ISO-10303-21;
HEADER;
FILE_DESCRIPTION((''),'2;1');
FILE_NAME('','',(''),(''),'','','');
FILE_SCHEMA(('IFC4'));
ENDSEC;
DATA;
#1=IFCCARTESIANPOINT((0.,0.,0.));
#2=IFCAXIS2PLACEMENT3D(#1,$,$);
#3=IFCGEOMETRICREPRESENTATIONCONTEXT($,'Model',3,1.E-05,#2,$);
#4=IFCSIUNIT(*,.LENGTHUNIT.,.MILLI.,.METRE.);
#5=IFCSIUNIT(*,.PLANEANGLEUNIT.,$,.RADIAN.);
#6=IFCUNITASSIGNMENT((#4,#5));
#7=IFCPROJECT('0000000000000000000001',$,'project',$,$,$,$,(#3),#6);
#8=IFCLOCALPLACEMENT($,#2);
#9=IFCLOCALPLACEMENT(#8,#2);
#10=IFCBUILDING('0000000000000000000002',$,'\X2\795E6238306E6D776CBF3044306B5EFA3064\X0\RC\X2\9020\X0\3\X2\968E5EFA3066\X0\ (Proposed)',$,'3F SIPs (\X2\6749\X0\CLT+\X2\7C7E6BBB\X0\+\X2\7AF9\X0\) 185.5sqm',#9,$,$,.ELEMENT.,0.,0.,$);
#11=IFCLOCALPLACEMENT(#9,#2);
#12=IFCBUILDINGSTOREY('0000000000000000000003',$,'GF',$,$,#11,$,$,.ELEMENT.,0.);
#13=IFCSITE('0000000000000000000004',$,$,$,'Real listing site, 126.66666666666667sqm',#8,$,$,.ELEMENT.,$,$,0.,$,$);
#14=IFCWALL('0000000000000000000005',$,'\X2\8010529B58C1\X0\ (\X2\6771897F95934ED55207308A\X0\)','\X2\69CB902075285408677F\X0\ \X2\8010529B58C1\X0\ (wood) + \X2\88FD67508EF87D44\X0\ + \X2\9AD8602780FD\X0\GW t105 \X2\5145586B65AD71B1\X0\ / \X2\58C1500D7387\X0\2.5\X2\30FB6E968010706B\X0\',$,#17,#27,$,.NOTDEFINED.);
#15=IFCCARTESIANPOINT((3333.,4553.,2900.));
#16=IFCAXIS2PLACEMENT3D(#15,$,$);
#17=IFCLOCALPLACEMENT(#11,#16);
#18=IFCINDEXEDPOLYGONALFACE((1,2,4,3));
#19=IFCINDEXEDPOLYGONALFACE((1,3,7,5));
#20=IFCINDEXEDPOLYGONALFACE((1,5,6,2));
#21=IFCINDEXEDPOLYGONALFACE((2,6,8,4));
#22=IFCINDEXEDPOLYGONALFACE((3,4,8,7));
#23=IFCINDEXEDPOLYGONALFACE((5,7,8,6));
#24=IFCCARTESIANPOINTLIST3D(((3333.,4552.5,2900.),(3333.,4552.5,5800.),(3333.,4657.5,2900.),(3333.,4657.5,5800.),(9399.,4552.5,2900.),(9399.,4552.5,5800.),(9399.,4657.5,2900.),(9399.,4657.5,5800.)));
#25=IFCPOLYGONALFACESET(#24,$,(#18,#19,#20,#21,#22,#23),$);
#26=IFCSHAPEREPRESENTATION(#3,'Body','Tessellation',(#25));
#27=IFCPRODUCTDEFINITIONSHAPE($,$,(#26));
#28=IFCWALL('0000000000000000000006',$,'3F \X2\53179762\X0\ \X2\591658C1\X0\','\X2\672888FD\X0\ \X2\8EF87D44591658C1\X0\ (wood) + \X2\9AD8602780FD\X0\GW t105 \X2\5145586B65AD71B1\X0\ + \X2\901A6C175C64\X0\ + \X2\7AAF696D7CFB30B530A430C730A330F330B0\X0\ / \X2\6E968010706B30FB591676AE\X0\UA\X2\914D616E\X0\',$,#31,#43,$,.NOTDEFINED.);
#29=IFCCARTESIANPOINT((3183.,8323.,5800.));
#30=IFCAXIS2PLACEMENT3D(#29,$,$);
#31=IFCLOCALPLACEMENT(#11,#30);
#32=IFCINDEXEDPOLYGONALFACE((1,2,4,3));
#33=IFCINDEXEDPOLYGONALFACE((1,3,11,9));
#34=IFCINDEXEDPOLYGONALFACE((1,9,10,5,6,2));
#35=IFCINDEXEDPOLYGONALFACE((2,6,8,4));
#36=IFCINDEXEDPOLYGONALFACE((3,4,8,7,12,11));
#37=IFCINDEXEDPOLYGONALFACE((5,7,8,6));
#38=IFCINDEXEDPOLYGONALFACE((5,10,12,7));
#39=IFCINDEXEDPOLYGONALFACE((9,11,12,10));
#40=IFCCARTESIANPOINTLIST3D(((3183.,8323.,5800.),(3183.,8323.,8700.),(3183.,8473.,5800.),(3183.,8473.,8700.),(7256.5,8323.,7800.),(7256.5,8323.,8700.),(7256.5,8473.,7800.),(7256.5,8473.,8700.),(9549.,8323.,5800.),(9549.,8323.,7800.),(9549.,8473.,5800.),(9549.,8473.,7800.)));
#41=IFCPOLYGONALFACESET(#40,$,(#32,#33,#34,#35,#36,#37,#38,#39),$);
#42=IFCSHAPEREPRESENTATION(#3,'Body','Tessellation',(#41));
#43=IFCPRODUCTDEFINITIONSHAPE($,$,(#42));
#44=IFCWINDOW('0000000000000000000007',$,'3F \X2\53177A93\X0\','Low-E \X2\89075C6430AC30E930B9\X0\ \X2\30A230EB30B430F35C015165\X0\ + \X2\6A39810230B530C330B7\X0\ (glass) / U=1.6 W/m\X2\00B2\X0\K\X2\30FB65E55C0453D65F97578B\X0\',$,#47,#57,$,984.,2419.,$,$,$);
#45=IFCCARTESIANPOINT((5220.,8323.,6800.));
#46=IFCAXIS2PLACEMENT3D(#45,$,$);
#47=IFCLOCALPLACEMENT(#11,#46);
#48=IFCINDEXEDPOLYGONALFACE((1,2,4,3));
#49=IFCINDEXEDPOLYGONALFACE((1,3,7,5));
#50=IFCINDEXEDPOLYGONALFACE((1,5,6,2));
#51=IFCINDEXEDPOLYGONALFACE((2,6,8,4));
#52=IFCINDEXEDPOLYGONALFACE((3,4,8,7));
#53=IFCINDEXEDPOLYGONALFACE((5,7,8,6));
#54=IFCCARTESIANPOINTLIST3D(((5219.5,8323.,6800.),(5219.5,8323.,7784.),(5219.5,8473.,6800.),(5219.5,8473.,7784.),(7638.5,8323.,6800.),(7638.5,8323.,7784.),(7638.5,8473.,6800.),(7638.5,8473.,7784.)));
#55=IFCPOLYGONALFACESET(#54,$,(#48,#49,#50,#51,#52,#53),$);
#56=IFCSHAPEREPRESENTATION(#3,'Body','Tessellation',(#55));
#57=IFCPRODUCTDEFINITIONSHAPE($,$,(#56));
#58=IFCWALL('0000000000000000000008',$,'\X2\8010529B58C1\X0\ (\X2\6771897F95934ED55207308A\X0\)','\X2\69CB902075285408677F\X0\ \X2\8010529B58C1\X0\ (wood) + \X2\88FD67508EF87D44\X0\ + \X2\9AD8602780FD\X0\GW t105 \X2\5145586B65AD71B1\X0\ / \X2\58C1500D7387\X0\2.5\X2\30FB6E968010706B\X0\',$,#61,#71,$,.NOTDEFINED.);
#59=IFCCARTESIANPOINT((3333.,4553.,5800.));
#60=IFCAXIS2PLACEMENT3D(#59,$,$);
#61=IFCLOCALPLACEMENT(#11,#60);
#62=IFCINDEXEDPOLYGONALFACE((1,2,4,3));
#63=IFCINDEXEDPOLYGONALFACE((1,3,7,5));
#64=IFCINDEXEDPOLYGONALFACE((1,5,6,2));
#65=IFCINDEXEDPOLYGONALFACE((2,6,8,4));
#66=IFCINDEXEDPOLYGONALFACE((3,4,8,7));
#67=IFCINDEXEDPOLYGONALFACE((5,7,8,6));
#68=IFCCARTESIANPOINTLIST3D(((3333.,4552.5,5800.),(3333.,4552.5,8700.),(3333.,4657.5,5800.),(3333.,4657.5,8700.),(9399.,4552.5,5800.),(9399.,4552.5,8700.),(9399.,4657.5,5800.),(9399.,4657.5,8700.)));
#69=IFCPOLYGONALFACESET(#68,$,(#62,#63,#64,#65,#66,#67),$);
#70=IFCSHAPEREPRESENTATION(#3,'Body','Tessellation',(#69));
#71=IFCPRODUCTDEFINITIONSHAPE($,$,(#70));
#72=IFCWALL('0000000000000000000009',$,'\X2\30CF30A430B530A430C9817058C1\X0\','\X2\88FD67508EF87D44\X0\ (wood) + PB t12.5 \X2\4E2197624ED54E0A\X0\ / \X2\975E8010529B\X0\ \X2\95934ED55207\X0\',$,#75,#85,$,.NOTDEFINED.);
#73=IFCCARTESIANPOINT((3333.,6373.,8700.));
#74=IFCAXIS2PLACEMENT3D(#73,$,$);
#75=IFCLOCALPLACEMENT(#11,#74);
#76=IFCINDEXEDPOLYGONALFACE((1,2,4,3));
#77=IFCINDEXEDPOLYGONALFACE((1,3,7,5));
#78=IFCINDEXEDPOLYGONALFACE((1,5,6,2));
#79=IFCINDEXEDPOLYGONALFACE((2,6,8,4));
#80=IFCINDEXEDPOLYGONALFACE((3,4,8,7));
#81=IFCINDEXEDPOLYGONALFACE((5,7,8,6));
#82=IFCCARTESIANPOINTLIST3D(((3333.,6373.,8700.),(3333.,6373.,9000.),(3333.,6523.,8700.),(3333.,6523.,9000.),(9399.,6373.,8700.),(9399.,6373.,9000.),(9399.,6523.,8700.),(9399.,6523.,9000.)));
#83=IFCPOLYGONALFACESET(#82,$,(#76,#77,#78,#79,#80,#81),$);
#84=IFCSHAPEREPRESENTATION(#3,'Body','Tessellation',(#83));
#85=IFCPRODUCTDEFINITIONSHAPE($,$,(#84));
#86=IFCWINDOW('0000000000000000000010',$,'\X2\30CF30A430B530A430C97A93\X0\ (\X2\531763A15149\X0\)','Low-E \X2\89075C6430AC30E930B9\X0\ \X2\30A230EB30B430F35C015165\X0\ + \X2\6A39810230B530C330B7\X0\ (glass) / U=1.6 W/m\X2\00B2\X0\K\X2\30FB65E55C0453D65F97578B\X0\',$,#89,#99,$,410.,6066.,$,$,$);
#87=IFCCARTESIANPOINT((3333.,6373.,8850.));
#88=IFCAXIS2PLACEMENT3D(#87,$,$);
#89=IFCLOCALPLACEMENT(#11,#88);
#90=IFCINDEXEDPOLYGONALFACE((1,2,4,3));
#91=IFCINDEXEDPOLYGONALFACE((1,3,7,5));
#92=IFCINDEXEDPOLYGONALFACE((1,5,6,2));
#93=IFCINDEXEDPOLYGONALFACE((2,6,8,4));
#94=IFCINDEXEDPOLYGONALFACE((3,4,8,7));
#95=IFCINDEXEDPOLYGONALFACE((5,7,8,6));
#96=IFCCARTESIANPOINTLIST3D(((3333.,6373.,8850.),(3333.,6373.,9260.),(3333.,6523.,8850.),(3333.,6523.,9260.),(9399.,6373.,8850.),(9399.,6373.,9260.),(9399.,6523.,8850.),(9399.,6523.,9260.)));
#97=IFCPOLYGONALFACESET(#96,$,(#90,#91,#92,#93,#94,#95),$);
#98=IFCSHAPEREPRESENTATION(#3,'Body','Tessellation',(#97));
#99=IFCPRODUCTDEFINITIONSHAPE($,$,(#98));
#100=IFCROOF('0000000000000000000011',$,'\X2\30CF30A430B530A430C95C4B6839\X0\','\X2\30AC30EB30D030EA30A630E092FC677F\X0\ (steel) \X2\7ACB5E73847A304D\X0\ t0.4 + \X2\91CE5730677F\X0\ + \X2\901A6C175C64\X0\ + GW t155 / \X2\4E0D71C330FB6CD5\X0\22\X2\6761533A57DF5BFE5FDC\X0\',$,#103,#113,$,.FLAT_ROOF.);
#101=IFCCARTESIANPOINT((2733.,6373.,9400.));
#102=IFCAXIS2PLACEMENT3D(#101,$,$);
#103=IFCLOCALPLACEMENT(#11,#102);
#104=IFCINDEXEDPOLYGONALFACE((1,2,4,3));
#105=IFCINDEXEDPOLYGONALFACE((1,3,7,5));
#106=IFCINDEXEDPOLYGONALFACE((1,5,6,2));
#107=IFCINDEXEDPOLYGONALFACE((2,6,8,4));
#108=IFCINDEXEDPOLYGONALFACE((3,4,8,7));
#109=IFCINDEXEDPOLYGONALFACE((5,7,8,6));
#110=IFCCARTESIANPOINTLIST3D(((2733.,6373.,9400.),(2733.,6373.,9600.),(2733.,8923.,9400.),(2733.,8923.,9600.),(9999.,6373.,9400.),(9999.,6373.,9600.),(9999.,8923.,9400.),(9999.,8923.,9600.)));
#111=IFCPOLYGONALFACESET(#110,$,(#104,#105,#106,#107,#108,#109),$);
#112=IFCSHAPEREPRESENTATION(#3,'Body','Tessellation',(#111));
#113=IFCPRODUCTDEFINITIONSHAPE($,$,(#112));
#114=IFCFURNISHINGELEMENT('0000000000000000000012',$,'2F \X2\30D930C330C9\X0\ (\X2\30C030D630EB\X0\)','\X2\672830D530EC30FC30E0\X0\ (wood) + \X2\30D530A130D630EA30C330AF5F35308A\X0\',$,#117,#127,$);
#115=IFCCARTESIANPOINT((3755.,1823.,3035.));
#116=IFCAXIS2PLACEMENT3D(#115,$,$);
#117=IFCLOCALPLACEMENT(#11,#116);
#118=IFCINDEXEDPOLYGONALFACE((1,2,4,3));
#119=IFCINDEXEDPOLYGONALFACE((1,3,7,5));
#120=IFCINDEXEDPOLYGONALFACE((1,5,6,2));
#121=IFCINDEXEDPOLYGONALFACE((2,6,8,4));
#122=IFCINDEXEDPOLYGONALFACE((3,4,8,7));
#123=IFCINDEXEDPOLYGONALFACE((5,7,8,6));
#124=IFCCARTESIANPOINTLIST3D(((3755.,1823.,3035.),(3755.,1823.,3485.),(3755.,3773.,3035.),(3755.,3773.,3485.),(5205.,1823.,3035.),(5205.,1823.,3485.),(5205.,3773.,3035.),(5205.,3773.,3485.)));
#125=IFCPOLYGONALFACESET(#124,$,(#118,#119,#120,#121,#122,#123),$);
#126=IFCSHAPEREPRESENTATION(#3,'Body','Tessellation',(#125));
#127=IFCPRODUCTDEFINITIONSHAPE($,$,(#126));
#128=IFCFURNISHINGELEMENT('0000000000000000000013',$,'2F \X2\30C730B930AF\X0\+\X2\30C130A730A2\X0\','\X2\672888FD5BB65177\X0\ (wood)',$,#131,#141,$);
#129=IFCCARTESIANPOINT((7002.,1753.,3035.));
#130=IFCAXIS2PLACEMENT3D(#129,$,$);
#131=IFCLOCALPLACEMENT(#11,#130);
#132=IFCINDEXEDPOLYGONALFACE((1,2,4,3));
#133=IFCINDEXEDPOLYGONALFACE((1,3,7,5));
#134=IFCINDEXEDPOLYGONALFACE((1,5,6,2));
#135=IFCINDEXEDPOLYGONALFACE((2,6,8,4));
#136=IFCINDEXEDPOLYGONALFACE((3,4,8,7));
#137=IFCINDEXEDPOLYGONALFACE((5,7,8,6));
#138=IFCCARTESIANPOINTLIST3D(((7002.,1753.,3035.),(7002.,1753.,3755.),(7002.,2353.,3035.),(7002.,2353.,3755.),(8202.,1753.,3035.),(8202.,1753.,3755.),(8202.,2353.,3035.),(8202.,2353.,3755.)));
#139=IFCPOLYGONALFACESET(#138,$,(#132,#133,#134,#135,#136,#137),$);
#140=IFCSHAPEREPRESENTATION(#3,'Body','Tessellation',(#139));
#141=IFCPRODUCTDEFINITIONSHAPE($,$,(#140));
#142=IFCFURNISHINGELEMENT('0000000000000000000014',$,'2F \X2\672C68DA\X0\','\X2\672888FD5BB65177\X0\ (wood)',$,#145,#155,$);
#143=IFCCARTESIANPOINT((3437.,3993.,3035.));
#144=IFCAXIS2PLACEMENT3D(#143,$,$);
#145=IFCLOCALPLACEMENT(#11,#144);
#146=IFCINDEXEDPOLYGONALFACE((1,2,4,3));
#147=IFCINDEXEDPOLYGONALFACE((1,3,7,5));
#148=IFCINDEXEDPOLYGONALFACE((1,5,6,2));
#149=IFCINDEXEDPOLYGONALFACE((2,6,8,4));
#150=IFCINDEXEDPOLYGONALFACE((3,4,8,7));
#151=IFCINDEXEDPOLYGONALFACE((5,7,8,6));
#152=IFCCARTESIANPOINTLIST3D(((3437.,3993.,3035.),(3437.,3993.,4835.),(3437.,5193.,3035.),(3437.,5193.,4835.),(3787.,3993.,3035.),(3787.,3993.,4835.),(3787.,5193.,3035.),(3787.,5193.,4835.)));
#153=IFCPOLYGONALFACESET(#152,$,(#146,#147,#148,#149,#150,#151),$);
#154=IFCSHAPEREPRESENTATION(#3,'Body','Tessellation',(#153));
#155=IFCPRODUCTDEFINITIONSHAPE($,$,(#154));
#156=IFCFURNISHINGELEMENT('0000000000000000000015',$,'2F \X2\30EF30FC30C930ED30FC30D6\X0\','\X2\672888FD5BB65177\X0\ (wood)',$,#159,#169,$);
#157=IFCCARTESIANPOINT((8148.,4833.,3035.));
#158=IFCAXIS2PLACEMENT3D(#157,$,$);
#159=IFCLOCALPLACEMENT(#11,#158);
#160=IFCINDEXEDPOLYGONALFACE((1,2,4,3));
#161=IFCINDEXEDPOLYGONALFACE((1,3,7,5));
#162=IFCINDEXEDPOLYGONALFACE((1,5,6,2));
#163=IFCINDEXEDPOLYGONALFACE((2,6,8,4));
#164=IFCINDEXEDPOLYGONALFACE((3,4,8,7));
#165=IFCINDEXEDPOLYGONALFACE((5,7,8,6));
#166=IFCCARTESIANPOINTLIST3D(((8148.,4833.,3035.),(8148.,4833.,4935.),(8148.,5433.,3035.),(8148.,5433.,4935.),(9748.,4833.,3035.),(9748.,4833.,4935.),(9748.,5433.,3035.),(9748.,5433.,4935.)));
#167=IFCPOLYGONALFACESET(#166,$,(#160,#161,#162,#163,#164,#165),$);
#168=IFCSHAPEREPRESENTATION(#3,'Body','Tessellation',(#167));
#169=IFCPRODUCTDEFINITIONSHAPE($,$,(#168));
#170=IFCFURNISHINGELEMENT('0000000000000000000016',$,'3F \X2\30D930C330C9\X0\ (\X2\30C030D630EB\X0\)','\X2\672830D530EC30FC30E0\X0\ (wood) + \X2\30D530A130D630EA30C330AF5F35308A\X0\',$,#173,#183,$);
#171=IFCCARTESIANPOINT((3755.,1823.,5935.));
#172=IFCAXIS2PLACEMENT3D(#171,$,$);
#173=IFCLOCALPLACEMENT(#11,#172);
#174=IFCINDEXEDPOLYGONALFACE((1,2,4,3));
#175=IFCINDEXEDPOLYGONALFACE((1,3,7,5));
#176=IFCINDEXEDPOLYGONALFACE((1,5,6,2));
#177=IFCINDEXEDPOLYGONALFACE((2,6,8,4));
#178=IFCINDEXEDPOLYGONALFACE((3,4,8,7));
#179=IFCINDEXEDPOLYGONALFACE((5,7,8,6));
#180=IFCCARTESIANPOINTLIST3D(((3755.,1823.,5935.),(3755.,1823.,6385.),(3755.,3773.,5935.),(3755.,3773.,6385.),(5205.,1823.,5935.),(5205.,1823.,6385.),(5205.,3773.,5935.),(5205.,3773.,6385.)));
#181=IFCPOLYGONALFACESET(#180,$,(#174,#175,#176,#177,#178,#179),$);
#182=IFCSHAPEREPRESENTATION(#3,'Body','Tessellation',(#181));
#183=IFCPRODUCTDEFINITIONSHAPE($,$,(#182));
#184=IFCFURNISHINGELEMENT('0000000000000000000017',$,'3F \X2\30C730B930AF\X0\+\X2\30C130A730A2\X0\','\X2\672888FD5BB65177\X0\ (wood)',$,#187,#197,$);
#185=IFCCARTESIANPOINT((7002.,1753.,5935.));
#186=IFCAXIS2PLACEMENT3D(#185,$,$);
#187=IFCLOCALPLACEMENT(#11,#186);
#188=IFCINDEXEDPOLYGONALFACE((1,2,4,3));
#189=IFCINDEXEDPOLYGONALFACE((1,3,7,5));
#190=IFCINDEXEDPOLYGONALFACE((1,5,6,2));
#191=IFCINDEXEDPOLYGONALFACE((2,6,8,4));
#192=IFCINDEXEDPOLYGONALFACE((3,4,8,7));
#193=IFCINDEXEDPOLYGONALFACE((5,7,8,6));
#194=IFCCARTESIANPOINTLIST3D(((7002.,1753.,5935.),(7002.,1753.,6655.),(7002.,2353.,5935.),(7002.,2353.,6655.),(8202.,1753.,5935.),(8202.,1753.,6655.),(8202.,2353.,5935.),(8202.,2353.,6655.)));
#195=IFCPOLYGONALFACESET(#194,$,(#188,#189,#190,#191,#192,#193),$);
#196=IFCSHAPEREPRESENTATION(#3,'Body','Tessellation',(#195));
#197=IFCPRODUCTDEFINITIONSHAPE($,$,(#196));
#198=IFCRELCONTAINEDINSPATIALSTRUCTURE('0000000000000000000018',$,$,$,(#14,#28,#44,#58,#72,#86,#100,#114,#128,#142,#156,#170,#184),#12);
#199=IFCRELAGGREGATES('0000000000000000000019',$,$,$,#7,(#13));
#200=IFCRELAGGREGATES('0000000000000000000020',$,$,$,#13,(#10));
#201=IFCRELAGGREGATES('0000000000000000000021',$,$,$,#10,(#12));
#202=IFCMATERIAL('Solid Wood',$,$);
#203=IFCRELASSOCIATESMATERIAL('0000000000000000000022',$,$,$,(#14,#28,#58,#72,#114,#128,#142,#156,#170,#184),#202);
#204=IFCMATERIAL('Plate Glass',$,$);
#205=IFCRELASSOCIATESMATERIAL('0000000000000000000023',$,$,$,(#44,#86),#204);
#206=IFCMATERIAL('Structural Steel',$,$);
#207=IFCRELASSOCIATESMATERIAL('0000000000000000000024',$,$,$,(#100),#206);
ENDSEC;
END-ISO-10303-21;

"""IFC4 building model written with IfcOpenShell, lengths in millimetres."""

from ifc_helpers import new_model, si_unit, frame, frame_2d, origin, place, context, project, spatial, rectangle, extrude, material, element, fill, save


model = new_model("IFC4")

# Units and contexts
model_context = context("Model", 3, precision=1e-05, world=origin())
ifc_project = project(units=[si_unit("LENGTHUNIT", "METRE", prefix="MILLI"), si_unit("PLANEANGLEUNIT", "RADIAN")], contexts=[model_context])

# Site, building, storey
site_placement = place(None, origin())
site = spatial("IfcSite", under=ifc_project, at=site_placement, ObjectType="Real listing site, 126.66666666666667sqm", CompositionType="ELEMENT", RefElevation=0.0)
building_placement = place(site_placement, origin())
building = spatial("IfcBuilding", under=site, at=building_placement, Name="神戸の海沿いに建つRC造3階建て (Proposed)", ObjectType="3F SIPs (杉CLT+籾殻+竹) 185.5sqm", CompositionType="ELEMENT", ElevationOfRefHeight=0.0, ElevationOfTerrain=0.0)
storey_placement = place(building_placement, origin())
storey = spatial("IfcBuildingStorey", under=building, at=storey_placement, Name="GF", CompositionType="ELEMENT", Elevation=0.0)

# Wall
ifc_material_1 = material(Name="Solid Wood")
wall_1_placement = place(storey_placement, frame((3333.0, 4553.0, 2900.0)))
element("IfcWall", 1, at=wall_1_placement, inside=storey, material=ifc_material_1, Name="耐力壁 (東西間仕切り)", Description="構造用合板 耐力壁 (wood) + 製材軸組 + 高性能GW t105 充填断熱 / 壁倍率2.5・準耐火", PredefinedType="NOTDEFINED", context=model_context, shape_type="SweptSolid", body=[
    extrude(rectangle(XDim=6066.0, YDim=105.0, at=frame_2d((3033.0, 52.0))), frame((3333.0, 4553.0, 2900.0)), (0.0, 0.0, 1.0), 2900.0),
])

# Wall, opening, window
wall_2_placement = place(storey_placement, frame((3183.0, 8323.0, 5800.0)))
wall_2 = element("IfcWall", 2, at=wall_2_placement, inside=storey, material=ifc_material_1, Name="3F 北面 外壁", Description="木製 軸組外壁 (wood) + 高性能GW t105 充填断熱 + 通気層 + 窯業系サイディング / 準耐火・外皮UA配慮", PredefinedType="NOTDEFINED", context=model_context, shape_type="SweptSolid", body=[
    extrude(rectangle(XDim=6366.0, YDim=150.0, at=frame_2d((3183.0, 75.0))), frame((3183.0, 8323.0, 5800.0)), (0.0, 0.0, 1.0), 2900.0),
])
opening_1_placement = place(storey_placement, frame((5220.0, 8323.0, 6800.0)))
opening_1 = element("IfcOpeningElement", 3, at=opening_1_placement, cuts=wall_2, PredefinedType="NOTDEFINED", context=model_context, shape_type="SweptSolid", body=[
    extrude(rectangle(XDim=2419.0, YDim=150.0, at=frame_2d((1209.0, 75.0))), frame((5220.0, 8323.0, 6800.0)), (0.0, 0.0, 1.0), 984.0),
])
ifc_material_2 = material(Name="Plate Glass")
window_1_placement = place(storey_placement, frame((5220.0, 8323.0, 6800.0)))
window_1 = element("IfcWindow", 4, at=window_1_placement, inside=storey, material=ifc_material_2, Name="3F 北窓", Description="Low-E 複層ガラス アルゴン封入 + 樹脂サッシ (glass) / U=1.6 W/m²K・日射取得型", OverallHeight=984.0, OverallWidth=2419.0, context=model_context, shape_type="SweptSolid", body=[
    extrude(rectangle(XDim=2419.0, YDim=150.0, at=frame_2d((1209.0, 75.0))), frame((5220.0, 8323.0, 6800.0)), (0.0, 0.0, 1.0), 984.0),
])
fill(opening_1, window_1)

# Wall
wall_3_placement = place(storey_placement, frame((3333.0, 4553.0, 5800.0)))
element("IfcWall", 5, at=wall_3_placement, inside=storey, material=ifc_material_1, Name="耐力壁 (東西間仕切り)", Description="構造用合板 耐力壁 (wood) + 製材軸組 + 高性能GW t105 充填断熱 / 壁倍率2.5・準耐火", PredefinedType="NOTDEFINED", context=model_context, shape_type="SweptSolid", body=[
    extrude(rectangle(XDim=6066.0, YDim=105.0, at=frame_2d((3033.0, 52.0))), frame((3333.0, 4553.0, 5800.0)), (0.0, 0.0, 1.0), 2900.0),
])

# Wall, opening, window
wall_4_placement = place(storey_placement, frame((3333.0, 6373.0, 8700.0)))
wall_4 = element("IfcWall", 6, at=wall_4_placement, inside=storey, material=ifc_material_1, Name="ハイサイド腰壁", Description="製材軸組 (wood) + PB t12.5 両面仕上 / 非耐力 間仕切", PredefinedType="NOTDEFINED", context=model_context, shape_type="SweptSolid", body=[
    extrude(rectangle(XDim=6066.0, YDim=150.0, at=frame_2d((3033.0, 75.0))), frame((3333.0, 6373.0, 8700.0)), (0.0, 0.0, 1.0), 700.0),
])
opening_2_placement = place(storey_placement, frame((3333.0, 6373.0, 8850.0)))
opening_2 = element("IfcOpeningElement", 7, at=opening_2_placement, cuts=wall_4, PredefinedType="NOTDEFINED", context=model_context, shape_type="SweptSolid", body=[
    extrude(rectangle(XDim=6066.0, YDim=150.0, at=frame_2d((3033.0, 75.0))), frame((3333.0, 6373.0, 8850.0)), (0.0, 0.0, 1.0), 410.0),
])
window_2_placement = place(storey_placement, frame((3333.0, 6373.0, 8850.0)))
window_2 = element("IfcWindow", 8, at=window_2_placement, inside=storey, material=ifc_material_2, Name="ハイサイド窓 (北採光)", Description="Low-E 複層ガラス アルゴン封入 + 樹脂サッシ (glass) / U=1.6 W/m²K・日射取得型", OverallHeight=410.0, OverallWidth=6066.0, context=model_context, shape_type="SweptSolid", body=[
    extrude(rectangle(XDim=6066.0, YDim=150.0, at=frame_2d((3033.0, 75.0))), frame((3333.0, 6373.0, 8850.0)), (0.0, 0.0, 1.0), 410.0),
])
fill(opening_2, window_2)

# Roof
ifc_material_3 = material(Name="Structural Steel")
roof_placement = place(storey_placement, frame((2733.0, 6373.0, 9400.0)))
element("IfcRoof", 9, at=roof_placement, inside=storey, material=ifc_material_3, Name="ハイサイド屋根", Description="ガルバリウム鋼板 (steel) 立平葺き t0.4 + 野地板 + 通気層 + GW t155 / 不燃・法22条区域対応", PredefinedType="FLAT_ROOF", context=model_context, shape_type="SweptSolid", body=[
    extrude(rectangle(XDim=7266.0, YDim=2550.0, at=frame_2d((3633.0, 1275.0))), frame((2733.0, 6373.0, 9400.0)), (0.0, 0.0, 1.0), 200.0),
])

# Furnishing elements
furnishing_1_placement = place(storey_placement, frame((3755.0, 1823.0, 3035.0)))
element("IfcFurnishingElement", 10, at=furnishing_1_placement, inside=storey, material=ifc_material_1, Name="2F ベッド (ダブル)", Description="木フレーム (wood) + ファブリック張り", context=model_context, shape_type="SweptSolid", body=[
    extrude(rectangle(XDim=1450.0, YDim=1950.0, at=frame_2d((725.0, 975.0))), frame((3755.0, 1823.0, 3035.0)), (0.0, 0.0, 1.0), 450.0),
])
furnishing_2_placement = place(storey_placement, frame((7002.0, 1753.0, 3035.0)))
element("IfcFurnishingElement", 11, at=furnishing_2_placement, inside=storey, material=ifc_material_1, Name="2F デスク+チェア", Description="木製家具 (wood)", context=model_context, shape_type="SweptSolid", body=[
    extrude(rectangle(XDim=1200.0, YDim=600.0, at=frame_2d((600.0, 300.0))), frame((7002.0, 1753.0, 3035.0)), (0.0, 0.0, 1.0), 720.0),
])
furnishing_3_placement = place(storey_placement, frame((3437.0, 3993.0, 3035.0)))
element("IfcFurnishingElement", 12, at=furnishing_3_placement, inside=storey, material=ifc_material_1, Name="2F 本棚", Description="木製家具 (wood)", context=model_context, shape_type="SweptSolid", body=[
    extrude(rectangle(XDim=350.0, YDim=1200.0, at=frame_2d((175.0, 600.0))), frame((3437.0, 3993.0, 3035.0)), (0.0, 0.0, 1.0), 1800.0),
])
furnishing_4_placement = place(storey_placement, frame((8148.0, 4833.0, 3035.0)))
element("IfcFurnishingElement", 13, at=furnishing_4_placement, inside=storey, material=ifc_material_1, Name="2F ワードローブ", Description="木製家具 (wood)", context=model_context, shape_type="SweptSolid", body=[
    extrude(rectangle(XDim=1600.0, YDim=600.0, at=frame_2d((800.0, 300.0))), frame((8148.0, 4833.0, 3035.0)), (0.0, 0.0, 1.0), 1900.0),
])
furnishing_5_placement = place(storey_placement, frame((3755.0, 1823.0, 5935.0)))
element("IfcFurnishingElement", 14, at=furnishing_5_placement, inside=storey, material=ifc_material_1, Name="3F ベッド (ダブル)", Description="木フレーム (wood) + ファブリック張り", context=model_context, shape_type="SweptSolid", body=[
    extrude(rectangle(XDim=1450.0, YDim=1950.0, at=frame_2d((725.0, 975.0))), frame((3755.0, 1823.0, 5935.0)), (0.0, 0.0, 1.0), 450.0),
])
furnishing_6_placement = place(storey_placement, frame((7002.0, 1753.0, 5935.0)))
element("IfcFurnishingElement", 15, at=furnishing_6_placement, inside=storey, material=ifc_material_1, Name="3F デスク+チェア", Description="木製家具 (wood)", context=model_context, shape_type="SweptSolid", body=[
    extrude(rectangle(XDim=1200.0, YDim=600.0, at=frame_2d((600.0, 300.0))), frame((7002.0, 1753.0, 5935.0)), (0.0, 0.0, 1.0), 720.0),
])

save(model, "model.ifc")
